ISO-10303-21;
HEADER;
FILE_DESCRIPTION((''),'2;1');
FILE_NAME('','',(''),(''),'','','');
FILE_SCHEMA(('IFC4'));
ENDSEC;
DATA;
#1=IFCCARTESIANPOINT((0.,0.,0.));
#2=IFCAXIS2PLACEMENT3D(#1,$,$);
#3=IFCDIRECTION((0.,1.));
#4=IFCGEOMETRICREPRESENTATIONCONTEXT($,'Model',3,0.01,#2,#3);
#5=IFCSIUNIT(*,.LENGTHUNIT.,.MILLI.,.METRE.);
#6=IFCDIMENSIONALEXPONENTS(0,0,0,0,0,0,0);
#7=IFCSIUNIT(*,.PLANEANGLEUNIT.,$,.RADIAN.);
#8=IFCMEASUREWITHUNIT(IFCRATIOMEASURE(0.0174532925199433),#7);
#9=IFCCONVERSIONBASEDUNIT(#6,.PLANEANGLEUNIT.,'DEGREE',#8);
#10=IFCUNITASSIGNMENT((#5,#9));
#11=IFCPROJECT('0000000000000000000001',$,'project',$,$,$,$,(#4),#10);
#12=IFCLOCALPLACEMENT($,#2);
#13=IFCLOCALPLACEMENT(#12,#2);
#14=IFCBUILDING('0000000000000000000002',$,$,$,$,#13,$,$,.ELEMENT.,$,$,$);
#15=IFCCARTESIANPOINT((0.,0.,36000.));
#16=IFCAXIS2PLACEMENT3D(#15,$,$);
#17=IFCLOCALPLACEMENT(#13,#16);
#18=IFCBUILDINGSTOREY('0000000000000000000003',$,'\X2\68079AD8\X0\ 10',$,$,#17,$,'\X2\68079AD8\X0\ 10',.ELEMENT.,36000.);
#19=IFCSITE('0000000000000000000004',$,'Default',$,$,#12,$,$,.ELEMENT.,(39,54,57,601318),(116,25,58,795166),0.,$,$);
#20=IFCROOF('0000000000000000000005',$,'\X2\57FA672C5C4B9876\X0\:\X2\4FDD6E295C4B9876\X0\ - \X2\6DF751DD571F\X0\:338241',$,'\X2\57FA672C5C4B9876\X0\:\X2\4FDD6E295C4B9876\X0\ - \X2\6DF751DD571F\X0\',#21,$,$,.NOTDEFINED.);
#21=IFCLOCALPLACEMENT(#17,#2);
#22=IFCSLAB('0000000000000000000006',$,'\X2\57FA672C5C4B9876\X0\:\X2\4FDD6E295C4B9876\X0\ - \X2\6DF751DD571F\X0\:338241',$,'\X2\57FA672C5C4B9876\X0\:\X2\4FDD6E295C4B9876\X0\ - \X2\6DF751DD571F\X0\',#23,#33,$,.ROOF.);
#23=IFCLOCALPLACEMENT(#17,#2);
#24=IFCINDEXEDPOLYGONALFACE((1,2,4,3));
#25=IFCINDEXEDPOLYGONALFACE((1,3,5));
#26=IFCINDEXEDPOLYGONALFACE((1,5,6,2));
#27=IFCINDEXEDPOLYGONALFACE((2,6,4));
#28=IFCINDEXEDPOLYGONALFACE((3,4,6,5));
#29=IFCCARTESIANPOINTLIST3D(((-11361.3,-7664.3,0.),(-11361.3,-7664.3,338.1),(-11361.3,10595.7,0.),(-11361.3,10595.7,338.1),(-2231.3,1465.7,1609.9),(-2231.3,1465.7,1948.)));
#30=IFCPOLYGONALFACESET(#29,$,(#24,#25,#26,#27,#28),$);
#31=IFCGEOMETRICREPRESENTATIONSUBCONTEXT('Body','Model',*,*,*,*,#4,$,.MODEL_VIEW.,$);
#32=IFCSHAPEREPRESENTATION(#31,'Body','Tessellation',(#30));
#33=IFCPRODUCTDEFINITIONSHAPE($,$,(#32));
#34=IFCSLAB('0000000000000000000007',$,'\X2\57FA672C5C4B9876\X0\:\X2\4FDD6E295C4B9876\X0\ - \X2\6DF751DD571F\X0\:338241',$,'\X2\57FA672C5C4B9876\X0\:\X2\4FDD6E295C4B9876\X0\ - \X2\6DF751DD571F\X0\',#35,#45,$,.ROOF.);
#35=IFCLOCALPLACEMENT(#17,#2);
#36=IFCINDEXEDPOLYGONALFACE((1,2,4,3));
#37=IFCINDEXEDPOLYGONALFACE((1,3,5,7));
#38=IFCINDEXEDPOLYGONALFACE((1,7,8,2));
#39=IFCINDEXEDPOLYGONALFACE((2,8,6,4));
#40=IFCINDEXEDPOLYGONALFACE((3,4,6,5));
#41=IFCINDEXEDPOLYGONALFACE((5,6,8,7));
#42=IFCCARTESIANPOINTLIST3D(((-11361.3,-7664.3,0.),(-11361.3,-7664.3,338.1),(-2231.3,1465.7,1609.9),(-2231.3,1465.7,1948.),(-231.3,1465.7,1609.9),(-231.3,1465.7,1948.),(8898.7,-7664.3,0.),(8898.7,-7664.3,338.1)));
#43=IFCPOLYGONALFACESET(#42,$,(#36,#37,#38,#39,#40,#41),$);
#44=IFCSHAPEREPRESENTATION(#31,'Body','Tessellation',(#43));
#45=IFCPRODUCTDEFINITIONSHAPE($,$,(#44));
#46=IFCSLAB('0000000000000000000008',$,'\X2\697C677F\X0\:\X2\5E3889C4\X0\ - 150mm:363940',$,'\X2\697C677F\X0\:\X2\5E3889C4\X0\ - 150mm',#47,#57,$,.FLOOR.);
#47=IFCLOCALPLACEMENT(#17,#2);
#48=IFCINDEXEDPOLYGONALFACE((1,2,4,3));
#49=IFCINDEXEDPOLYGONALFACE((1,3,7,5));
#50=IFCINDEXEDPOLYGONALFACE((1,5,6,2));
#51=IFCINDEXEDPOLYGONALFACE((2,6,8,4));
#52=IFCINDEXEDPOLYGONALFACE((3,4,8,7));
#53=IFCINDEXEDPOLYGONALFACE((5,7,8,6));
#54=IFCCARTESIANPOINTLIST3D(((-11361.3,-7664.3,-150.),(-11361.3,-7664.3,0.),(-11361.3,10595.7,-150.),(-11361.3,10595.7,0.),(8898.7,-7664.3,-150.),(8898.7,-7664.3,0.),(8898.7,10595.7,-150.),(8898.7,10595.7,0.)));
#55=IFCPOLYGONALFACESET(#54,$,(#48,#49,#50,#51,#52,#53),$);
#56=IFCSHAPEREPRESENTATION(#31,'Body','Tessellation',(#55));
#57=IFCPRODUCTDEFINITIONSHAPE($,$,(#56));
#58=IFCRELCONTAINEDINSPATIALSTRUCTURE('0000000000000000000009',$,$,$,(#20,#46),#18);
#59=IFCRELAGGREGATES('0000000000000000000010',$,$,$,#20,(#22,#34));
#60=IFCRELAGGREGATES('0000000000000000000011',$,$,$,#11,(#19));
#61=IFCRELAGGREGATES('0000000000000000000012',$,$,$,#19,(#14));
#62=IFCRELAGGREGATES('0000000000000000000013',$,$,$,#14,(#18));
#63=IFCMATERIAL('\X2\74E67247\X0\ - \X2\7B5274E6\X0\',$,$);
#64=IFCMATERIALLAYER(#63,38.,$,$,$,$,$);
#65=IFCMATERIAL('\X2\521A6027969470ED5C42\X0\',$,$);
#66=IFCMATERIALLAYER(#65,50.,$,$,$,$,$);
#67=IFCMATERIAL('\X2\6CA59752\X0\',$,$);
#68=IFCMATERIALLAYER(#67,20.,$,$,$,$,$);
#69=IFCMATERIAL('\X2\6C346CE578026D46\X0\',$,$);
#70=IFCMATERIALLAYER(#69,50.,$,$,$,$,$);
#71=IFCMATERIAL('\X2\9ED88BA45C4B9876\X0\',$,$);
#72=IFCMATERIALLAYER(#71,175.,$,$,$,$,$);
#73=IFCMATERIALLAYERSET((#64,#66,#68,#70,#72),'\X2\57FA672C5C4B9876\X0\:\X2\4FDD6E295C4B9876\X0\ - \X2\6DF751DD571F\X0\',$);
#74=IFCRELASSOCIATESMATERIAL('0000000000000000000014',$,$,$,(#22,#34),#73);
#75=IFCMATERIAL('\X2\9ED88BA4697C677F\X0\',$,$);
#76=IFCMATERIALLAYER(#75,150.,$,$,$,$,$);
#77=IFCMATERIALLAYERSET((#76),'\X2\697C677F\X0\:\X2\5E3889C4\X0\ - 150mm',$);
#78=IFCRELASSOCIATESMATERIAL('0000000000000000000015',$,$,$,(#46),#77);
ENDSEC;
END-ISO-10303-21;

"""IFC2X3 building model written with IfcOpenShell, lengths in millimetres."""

from ifc_helpers import new_model, entity, si_unit, converted_unit, direction, frame, origin, origin_2d_with_axis, place, context, subcontext, project, spatial, polyline, rectangle, outline, extrude, material, layer, layer_set, layer_usage, element, aggregate, save


model = new_model("IFC2X3")

# Units and contexts
model_context = context("Model", 3, precision=0.01, world=origin(), true_north=direction((0.0, 1.0)))
body_context = subcontext(model_context, "Body", "Model", "MODEL_VIEW")
ifc_project = project(units=[si_unit("LENGTHUNIT", "METRE", prefix="MILLI"), converted_unit("PLANEANGLEUNIT", "DEGREE", entity("IfcRatioMeasure", 0.0174532925199433), si_unit("PLANEANGLEUNIT", "RADIAN"), dimensions=[0, 0, 0, 0, 0, 0, 0])], contexts=[model_context])

# Site, building, storey
site_placement = place(None, origin())
site = spatial("IfcSite", under=ifc_project, at=site_placement, Name="Default", CompositionType="ELEMENT", RefLatitude=(39, 54, 57, 601318), RefLongitude=(116, 25, 58, 795166), RefElevation=0.0)
building_placement = place(site_placement, origin())
building = spatial("IfcBuilding", under=site, at=building_placement, CompositionType="ELEMENT")
storey_placement = place(building_placement, frame((0.0, 0.0, 36000.0)))
storey = spatial("IfcBuildingStorey", under=building, at=storey_placement, Name="标高 10", LongName="标高 10", CompositionType="ELEMENT", Elevation=36000.0)

# Roof, slabs
roof_placement = place(storey_placement, frame((-11361.3, -7664.3, 0.0)))
roof = element("IfcRoof", 1, at=roof_placement, inside=storey, Name="基本屋顶:保温屋顶 - 混凝土:338241", ObjectType="基本屋顶:保温屋顶 - 混凝土", ShapeType="NOTDEFINED")
ifc_material_1 = material(Name="瓦片 - 筒瓦")
ifc_layer_1 = layer(ifc_material_1, 38.0)
ifc_material_2 = material(Name="刚性隔热层")
ifc_layer_2 = layer(ifc_material_2, 50.0)
ifc_material_3 = material(Name="沥青")
ifc_layer_3 = layer(ifc_material_3, 20.0)
ifc_material_4 = material(Name="水泥砂浆")
ifc_layer_4 = layer(ifc_material_4, 50.0)
ifc_material_5 = material(Name="默认屋顶")
ifc_layer_5 = layer(ifc_material_5, 175.0)
ifc_layer_set_1 = layer_set([ifc_layer_1, ifc_layer_2, ifc_layer_3, ifc_layer_4, ifc_layer_5], Name="基本屋顶:保温屋顶 - 混凝土")
slab_1_placement = place(roof_placement, origin())
slab_1 = element("IfcSlab", 2, at=slab_1_placement, material=ifc_layer_set_1, Name="基本屋顶:保温屋顶 - 混凝土:338241", ObjectType="基本屋顶:保温屋顶 - 混凝土", PredefinedType="ROOF", context=body_context, shape_type="SweptSolid", body=[
    extrude(outline(polyline([(4635.4, 0.0), (-4635.4, 9130.0), (-4635.4, -9130.0), (4635.4, 0.0)])), frame((4565.0, 9130.0, 804.9), z_axis=(-0.173648, 0.0, 0.984808), x_axis=(0.984808, 0.0, 0.173648)), (0.173648, 0.0, 0.984808), 338.1),
])
slab_2_placement = place(roof_placement, origin())
slab_2 = element("IfcSlab", 3, at=slab_2_placement, material=ifc_layer_set_1, Name="基本屋顶:保温屋顶 - 混凝土:338241", ObjectType="基本屋顶:保温屋顶 - 混凝土", PredefinedType="ROOF", context=body_context, shape_type="SweptSolid", body=[
    extrude(outline(polyline([(-10130.0, -4635.4), (10130.0, -4635.4), (1000.0, 4635.4), (-1000.0, 4635.4), (-10130.0, -4635.4)])), frame((10130.0, 4565.0, 804.9), z_axis=(0.0, -0.173648, 0.984808), x_axis=(1.0, 0.0, 0.0)), (0.0, 0.173648, 0.984808), 338.1),
])
aggregate(roof, [slab_1, slab_2])

# Slab
ifc_material_6 = material(Name="默认楼板")
ifc_layer_6 = layer(ifc_material_6, 150.0)
ifc_layer_set_2 = layer_set([ifc_layer_6], Name="楼板:常规 - 150mm")
ifc_layer_usage = layer_usage(ifc_layer_set_2, "AXIS3", "POSITIVE", 0.0)
slab_3_placement = place(storey_placement, origin())
element("IfcSlab", 4, at=slab_3_placement, inside=storey, material=ifc_layer_usage, Name="楼板:常规 - 150mm:363940", ObjectType="楼板:常规 - 150mm", PredefinedType="FLOOR", context=body_context, shape_type="SweptSolid", body=[
    extrude(rectangle(XDim=18260.0, YDim=20260.0, at=origin_2d_with_axis()), frame((-1231.3, 1465.7, 0.0), z_axis=(0.0, 0.0, -1.0), x_axis=(0.0, 1.0, 0.0)), (0.0, 0.0, 1.0), 150.0),
])

save(model, "model.ifc")
